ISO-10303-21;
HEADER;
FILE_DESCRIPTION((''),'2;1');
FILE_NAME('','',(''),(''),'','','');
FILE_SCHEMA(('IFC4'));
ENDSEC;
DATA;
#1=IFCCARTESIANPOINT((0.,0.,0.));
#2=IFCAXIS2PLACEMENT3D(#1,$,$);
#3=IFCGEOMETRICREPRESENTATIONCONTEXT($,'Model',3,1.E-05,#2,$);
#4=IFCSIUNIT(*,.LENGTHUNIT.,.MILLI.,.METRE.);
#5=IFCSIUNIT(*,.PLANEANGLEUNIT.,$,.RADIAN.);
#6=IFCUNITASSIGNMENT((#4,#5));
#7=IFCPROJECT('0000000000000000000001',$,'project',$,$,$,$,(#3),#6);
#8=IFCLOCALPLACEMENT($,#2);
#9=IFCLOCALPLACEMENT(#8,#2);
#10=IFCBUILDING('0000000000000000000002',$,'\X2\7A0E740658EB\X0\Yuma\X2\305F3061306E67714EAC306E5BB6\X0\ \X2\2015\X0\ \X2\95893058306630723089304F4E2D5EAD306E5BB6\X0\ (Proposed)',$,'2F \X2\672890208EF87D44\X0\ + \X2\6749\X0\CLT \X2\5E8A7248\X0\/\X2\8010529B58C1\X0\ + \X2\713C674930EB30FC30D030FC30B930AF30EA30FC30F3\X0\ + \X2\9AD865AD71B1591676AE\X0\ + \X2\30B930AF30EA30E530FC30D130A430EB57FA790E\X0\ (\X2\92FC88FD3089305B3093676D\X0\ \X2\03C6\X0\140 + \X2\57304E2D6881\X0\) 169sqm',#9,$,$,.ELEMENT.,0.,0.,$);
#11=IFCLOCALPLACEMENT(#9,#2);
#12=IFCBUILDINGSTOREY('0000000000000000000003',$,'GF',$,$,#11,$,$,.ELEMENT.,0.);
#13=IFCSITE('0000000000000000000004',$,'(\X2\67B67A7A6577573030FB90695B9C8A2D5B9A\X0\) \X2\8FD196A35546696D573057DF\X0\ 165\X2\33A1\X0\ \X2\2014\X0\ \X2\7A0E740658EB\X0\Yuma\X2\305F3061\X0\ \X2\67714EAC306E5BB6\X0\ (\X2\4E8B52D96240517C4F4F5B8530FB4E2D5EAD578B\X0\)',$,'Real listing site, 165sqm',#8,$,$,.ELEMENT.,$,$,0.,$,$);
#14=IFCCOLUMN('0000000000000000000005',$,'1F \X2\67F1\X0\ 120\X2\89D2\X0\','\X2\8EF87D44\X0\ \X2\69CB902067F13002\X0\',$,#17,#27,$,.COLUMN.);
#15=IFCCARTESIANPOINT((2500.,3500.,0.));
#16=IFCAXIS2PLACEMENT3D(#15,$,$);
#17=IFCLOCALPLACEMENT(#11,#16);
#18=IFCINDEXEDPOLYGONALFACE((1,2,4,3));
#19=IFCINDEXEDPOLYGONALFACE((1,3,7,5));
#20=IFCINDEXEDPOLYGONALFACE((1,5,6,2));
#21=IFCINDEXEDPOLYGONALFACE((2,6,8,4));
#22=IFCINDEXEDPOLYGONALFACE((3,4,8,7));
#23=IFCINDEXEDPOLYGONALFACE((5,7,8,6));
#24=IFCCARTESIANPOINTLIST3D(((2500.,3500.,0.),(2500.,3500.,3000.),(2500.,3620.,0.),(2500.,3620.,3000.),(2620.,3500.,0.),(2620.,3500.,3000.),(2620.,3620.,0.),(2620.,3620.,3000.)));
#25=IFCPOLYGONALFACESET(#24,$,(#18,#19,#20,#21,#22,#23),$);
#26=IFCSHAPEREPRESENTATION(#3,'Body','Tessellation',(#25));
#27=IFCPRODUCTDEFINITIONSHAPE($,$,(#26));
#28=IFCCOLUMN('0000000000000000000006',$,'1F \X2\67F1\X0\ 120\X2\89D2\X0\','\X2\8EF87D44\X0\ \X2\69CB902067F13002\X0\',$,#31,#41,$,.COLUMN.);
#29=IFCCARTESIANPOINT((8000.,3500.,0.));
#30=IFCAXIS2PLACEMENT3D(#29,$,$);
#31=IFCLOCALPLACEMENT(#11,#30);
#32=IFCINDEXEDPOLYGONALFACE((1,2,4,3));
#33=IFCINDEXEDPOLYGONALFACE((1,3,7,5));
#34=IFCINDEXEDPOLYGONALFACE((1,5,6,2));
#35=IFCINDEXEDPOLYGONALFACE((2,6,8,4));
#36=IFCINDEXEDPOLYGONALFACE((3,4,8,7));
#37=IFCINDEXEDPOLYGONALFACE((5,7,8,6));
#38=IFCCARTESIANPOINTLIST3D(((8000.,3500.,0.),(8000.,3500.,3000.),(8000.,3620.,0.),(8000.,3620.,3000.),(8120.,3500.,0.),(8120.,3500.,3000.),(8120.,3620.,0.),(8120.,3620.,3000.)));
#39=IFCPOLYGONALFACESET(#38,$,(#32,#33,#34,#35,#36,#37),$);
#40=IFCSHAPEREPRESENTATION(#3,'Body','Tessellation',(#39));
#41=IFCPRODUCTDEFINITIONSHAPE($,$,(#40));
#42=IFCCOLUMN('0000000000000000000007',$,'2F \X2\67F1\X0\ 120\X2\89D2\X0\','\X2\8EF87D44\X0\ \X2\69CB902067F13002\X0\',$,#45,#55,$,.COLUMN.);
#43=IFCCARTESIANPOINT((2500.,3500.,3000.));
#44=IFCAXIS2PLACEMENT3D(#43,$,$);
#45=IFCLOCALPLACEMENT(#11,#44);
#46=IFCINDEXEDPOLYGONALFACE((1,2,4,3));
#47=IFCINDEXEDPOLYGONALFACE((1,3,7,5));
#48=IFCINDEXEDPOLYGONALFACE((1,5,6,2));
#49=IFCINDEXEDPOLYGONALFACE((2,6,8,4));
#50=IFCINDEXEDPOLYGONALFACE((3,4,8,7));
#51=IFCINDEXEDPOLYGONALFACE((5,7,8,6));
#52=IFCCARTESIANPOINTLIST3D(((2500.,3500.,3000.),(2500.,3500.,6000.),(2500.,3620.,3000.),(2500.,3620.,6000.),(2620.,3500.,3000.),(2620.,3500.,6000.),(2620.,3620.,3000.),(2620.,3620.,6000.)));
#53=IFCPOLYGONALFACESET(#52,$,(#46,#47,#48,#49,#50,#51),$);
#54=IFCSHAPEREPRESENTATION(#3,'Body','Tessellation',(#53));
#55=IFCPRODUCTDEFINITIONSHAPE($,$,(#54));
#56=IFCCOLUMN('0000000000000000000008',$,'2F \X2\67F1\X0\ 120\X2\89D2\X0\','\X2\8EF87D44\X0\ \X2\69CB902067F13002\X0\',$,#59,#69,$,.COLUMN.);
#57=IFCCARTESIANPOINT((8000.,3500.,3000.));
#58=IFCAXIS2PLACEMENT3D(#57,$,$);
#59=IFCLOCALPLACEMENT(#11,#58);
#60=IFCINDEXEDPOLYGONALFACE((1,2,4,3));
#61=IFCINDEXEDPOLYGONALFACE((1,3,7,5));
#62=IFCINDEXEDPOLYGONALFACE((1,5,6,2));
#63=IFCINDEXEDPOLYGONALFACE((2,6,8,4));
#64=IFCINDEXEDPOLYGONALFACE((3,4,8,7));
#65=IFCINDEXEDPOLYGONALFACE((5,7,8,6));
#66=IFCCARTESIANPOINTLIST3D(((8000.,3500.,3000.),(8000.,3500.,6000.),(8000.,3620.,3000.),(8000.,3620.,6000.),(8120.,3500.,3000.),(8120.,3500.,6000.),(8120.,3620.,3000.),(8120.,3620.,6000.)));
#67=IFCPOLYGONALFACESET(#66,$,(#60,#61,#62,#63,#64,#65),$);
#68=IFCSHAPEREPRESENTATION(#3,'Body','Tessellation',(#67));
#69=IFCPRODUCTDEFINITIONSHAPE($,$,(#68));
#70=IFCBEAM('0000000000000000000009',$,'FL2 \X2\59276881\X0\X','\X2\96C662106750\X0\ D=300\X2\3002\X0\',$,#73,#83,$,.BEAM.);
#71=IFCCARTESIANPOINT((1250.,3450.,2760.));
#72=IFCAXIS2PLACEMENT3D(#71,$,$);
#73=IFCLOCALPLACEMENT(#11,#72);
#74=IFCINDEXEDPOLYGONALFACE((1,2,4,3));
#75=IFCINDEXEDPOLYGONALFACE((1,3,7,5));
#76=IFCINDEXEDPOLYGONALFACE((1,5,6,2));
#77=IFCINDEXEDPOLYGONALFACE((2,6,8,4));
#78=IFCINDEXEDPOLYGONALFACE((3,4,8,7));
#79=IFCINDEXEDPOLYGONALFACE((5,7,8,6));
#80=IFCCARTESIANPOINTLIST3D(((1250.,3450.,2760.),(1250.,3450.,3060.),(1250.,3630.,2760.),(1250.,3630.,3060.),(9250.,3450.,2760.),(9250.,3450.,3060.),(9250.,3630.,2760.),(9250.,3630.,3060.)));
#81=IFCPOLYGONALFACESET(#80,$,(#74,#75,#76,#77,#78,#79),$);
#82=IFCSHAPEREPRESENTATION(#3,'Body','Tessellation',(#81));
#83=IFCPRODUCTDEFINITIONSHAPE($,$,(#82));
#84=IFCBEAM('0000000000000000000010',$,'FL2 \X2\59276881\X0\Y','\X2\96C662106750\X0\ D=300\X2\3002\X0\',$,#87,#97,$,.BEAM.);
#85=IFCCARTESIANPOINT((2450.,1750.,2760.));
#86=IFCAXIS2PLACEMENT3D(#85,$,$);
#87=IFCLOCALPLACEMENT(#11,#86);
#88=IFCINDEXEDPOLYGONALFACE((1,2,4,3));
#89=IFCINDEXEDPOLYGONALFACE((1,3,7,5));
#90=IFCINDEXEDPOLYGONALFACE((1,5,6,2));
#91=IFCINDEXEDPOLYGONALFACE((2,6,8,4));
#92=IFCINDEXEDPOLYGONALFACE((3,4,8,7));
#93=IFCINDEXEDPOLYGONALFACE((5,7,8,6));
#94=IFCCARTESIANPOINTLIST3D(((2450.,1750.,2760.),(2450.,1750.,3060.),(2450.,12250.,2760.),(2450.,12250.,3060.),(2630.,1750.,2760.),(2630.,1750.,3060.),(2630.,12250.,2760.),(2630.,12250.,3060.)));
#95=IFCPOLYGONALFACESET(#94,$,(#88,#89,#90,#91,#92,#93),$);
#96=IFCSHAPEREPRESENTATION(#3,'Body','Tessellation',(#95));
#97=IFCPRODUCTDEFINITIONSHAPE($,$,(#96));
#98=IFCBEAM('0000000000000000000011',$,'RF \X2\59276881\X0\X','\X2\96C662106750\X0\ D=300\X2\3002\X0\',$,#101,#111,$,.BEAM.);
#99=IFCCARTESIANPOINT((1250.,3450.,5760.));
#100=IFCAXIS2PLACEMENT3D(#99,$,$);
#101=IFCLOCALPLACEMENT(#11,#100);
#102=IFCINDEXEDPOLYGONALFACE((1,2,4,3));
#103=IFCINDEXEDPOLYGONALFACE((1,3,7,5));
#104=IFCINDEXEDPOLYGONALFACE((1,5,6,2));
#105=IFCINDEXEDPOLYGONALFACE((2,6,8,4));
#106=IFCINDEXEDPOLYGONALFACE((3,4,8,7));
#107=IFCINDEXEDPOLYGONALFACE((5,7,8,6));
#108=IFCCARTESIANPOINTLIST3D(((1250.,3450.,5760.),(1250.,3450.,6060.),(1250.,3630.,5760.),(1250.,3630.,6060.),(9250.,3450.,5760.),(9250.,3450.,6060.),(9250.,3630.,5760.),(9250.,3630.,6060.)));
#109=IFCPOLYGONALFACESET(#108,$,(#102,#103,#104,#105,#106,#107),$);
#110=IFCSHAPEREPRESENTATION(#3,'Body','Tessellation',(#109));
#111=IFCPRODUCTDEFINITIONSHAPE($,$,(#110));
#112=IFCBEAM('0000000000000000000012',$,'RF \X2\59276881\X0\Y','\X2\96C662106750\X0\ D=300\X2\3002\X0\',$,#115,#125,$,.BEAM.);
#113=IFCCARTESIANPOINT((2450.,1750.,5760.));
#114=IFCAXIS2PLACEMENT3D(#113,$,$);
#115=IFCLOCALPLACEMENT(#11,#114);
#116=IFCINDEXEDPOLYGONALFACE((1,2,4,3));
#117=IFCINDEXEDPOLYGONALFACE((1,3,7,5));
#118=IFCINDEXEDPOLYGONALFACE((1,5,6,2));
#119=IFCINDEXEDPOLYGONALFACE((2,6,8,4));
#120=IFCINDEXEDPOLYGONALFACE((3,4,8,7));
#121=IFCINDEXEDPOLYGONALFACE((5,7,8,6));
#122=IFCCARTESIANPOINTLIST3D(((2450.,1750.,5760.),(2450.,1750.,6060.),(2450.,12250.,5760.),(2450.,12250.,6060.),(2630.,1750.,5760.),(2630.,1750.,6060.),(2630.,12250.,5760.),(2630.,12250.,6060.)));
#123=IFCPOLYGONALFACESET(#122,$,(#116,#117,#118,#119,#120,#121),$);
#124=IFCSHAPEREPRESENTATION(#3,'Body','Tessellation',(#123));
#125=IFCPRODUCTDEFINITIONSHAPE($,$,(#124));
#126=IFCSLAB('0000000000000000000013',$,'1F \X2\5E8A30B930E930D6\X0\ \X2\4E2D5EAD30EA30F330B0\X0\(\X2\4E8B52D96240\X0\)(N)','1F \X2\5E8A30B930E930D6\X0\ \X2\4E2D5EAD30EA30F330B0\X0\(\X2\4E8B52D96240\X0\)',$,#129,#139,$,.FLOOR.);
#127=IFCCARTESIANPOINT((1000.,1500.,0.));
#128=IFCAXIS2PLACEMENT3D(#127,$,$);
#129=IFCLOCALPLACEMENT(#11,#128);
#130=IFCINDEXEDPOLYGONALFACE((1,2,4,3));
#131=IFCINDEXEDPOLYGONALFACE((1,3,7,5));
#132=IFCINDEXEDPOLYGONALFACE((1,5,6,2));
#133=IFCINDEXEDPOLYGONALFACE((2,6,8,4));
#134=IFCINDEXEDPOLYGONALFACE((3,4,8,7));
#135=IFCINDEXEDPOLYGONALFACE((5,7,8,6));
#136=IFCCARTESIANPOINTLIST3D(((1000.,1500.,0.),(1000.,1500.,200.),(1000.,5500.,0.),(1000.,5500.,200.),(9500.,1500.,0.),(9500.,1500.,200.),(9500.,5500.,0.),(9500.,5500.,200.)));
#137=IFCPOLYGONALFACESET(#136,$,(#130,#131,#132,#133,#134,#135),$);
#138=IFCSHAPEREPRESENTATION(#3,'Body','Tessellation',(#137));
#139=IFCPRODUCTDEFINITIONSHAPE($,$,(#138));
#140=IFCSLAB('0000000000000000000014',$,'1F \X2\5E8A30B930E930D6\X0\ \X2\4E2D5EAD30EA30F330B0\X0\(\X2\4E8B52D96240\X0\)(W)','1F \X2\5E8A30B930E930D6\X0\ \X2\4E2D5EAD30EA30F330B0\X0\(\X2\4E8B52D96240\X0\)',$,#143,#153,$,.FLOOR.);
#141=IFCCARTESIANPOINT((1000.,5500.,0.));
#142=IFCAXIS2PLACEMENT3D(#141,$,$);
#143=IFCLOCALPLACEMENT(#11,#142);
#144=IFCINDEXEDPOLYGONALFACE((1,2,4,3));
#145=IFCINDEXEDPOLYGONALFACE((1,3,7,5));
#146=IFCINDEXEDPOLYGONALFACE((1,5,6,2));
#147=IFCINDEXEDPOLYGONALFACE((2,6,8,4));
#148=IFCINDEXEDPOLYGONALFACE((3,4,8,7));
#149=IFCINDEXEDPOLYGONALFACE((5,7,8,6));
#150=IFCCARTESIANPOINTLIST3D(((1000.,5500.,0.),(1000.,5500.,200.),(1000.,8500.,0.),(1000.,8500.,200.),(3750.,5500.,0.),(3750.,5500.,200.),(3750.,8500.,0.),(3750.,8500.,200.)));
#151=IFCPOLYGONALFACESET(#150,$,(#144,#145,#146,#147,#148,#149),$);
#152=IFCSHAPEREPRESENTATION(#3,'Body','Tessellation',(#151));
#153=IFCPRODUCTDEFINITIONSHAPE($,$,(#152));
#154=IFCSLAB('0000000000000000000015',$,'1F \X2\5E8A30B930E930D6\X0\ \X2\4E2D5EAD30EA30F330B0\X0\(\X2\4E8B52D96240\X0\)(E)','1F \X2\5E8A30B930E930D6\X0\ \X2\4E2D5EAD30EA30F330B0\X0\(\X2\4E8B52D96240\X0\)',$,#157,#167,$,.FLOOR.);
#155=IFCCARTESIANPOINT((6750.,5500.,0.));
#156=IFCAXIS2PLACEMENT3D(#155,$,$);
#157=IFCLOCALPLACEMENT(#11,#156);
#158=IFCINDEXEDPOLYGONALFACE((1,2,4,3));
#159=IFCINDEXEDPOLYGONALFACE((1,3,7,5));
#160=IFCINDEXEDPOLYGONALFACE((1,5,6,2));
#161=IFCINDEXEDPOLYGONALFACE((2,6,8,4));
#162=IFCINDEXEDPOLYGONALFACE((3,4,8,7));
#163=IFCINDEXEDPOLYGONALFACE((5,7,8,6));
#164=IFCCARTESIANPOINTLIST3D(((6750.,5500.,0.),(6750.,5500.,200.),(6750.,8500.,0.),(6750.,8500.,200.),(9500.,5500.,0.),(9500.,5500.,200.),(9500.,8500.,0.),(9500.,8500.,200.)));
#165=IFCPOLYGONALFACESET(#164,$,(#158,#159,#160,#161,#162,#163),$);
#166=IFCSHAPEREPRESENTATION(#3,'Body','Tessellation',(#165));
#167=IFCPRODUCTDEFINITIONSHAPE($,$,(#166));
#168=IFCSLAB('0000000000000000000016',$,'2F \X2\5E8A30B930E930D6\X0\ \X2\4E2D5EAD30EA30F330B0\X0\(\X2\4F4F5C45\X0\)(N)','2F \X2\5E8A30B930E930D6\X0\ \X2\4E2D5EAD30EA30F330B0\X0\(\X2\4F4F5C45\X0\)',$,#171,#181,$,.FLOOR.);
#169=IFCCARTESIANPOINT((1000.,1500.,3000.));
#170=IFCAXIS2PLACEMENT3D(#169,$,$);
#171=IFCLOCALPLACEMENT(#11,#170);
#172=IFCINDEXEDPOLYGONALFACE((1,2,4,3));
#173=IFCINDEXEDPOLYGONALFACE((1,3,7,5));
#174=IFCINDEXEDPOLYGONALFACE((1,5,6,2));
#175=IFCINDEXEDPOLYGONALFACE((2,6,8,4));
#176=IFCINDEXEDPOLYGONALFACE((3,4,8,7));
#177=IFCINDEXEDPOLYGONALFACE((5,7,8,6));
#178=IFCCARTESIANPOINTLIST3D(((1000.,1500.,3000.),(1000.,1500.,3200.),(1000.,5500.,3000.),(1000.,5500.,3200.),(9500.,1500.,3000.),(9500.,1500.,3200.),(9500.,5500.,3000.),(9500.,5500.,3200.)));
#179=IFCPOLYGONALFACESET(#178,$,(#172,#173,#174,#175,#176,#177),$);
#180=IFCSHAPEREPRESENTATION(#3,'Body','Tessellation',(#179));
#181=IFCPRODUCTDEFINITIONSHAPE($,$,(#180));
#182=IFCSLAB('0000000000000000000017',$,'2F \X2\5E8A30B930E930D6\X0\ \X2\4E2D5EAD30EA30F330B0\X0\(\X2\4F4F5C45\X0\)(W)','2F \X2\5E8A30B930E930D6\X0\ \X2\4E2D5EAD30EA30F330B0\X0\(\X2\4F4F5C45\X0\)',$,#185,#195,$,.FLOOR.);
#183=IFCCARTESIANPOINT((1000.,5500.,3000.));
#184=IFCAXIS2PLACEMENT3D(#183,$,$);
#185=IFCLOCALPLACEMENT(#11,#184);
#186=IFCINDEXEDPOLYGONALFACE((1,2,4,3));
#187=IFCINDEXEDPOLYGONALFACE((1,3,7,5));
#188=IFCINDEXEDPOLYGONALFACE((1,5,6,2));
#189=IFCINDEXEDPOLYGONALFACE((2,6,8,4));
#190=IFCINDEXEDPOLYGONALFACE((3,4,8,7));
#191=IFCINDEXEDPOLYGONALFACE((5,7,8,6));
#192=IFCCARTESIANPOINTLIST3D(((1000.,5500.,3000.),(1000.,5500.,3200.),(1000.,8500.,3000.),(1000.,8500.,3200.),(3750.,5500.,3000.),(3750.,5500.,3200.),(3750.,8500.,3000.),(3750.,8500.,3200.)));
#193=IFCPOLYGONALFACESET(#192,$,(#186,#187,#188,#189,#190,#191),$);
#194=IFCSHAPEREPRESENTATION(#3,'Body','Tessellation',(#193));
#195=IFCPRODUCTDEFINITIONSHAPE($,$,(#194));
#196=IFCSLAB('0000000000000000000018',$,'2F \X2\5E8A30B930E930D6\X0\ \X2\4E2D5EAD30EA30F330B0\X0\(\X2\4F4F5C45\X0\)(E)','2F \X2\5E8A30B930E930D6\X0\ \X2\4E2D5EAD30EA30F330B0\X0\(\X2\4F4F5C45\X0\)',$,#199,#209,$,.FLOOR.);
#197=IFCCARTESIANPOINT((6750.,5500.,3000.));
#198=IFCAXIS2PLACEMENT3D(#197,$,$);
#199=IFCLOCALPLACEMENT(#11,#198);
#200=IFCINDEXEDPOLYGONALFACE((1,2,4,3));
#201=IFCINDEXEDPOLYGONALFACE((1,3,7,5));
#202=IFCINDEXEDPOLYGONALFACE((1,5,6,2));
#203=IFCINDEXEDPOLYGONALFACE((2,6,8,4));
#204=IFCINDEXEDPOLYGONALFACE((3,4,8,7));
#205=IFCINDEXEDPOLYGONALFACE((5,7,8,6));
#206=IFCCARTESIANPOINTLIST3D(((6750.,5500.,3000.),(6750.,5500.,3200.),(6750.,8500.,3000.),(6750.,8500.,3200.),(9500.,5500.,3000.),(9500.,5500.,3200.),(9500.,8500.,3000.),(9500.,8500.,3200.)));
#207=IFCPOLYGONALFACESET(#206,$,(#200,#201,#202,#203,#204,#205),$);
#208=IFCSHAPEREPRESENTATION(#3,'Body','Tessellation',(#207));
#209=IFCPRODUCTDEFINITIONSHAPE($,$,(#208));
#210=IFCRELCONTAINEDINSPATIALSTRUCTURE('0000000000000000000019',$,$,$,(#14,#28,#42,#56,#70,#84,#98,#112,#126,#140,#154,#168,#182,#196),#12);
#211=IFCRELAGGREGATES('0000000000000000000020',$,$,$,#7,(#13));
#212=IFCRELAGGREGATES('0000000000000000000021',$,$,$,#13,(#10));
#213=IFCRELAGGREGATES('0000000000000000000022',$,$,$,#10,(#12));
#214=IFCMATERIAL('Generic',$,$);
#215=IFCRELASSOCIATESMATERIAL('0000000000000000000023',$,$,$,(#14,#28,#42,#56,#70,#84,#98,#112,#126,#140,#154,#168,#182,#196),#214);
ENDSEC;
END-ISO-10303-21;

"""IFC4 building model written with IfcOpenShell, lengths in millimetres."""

from ifc_helpers import new_model, si_unit, frame, frame_2d, origin, place, context, project, spatial, rectangle, extrude, material, element, save


model = new_model("IFC4")

# Units and contexts
model_context = context("Model", 3, precision=1e-05, world=origin())
ifc_project = project(units=[si_unit("LENGTHUNIT", "METRE", prefix="MILLI"), si_unit("PLANEANGLEUNIT", "RADIAN")], contexts=[model_context])

# Site, building, storey
site_placement = place(None, origin())
site = spatial("IfcSite", under=ifc_project, at=site_placement, Name="(架空敷地・適宜設定) 近隣商業地域 165㎡ — 税理士Yumaたち 東京の家 (事務所兼住宅・中庭型)", ObjectType="Real listing site, 165sqm", CompositionType="ELEMENT", RefElevation=0.0)
building_placement = place(site_placement, origin())
building = spatial("IfcBuilding", under=site, at=building_placement, Name="税理士Yumaたちの東京の家 ― 閉じてひらく中庭の家 (Proposed)", ObjectType="2F 木造軸組 + 杉CLT 床版/耐力壁 + 焼杉ルーバースクリーン + 高断熱外皮 + スクリューパイル基礎 (鋼製らせん杭 φ140 + 地中梁) 169sqm", CompositionType="ELEMENT", ElevationOfRefHeight=0.0, ElevationOfTerrain=0.0)
storey_placement = place(building_placement, origin())
storey = spatial("IfcBuildingStorey", under=building, at=storey_placement, Name="GF", CompositionType="ELEMENT", Elevation=0.0)

# Columns
ifc_material_1 = material(Name="Generic")
column_1_placement = place(storey_placement, frame((2500.0, 3500.0, 0.0)))
element("IfcColumn", 1, at=column_1_placement, inside=storey, material=ifc_material_1, Name="1F 柱 120角", Description="軸組 構造柱。", PredefinedType="COLUMN", context=model_context, shape_type="SweptSolid", body=[
    extrude(rectangle(XDim=120.0, YDim=120.0, at=frame_2d((60.0, 60.0))), frame((2500.0, 3500.0, 0.0)), (0.0, 0.0, 1.0), 3000.0),
])
column_2_placement = place(storey_placement, frame((8000.0, 3500.0, 0.0)))
element("IfcColumn", 2, at=column_2_placement, inside=storey, material=ifc_material_1, Name="1F 柱 120角", Description="軸組 構造柱。", PredefinedType="COLUMN", context=model_context, shape_type="SweptSolid", body=[
    extrude(rectangle(XDim=120.0, YDim=120.0, at=frame_2d((60.0, 60.0))), frame((8000.0, 3500.0, 0.0)), (0.0, 0.0, 1.0), 3000.0),
])
column_3_placement = place(storey_placement, frame((2500.0, 3500.0, 3000.0)))
element("IfcColumn", 3, at=column_3_placement, inside=storey, material=ifc_material_1, Name="2F 柱 120角", Description="軸組 構造柱。", PredefinedType="COLUMN", context=model_context, shape_type="SweptSolid", body=[
    extrude(rectangle(XDim=120.0, YDim=120.0, at=frame_2d((60.0, 60.0))), frame((2500.0, 3500.0, 3000.0)), (0.0, 0.0, 1.0), 3000.0),
])
column_4_placement = place(storey_placement, frame((8000.0, 3500.0, 3000.0)))
element("IfcColumn", 4, at=column_4_placement, inside=storey, material=ifc_material_1, Name="2F 柱 120角", Description="軸組 構造柱。", PredefinedType="COLUMN", context=model_context, shape_type="SweptSolid", body=[
    extrude(rectangle(XDim=120.0, YDim=120.0, at=frame_2d((60.0, 60.0))), frame((8000.0, 3500.0, 3000.0)), (0.0, 0.0, 1.0), 3000.0),
])

# Beams
beam_1_placement = place(storey_placement, frame((1250.0, 3450.0, 2760.0)))
element("IfcBeam", 5, at=beam_1_placement, inside=storey, material=ifc_material_1, Name="FL2 大梁X", Description="集成材 D=300。", PredefinedType="BEAM", context=model_context, shape_type="SweptSolid", body=[
    extrude(rectangle(XDim=8000.0, YDim=180.0, at=frame_2d((4000.0, 90.0))), frame((1250.0, 3450.0, 2760.0)), (0.0, 0.0, 1.0), 300.0),
])
beam_2_placement = place(storey_placement, frame((2450.0, 1750.0, 2760.0)))
element("IfcBeam", 6, at=beam_2_placement, inside=storey, material=ifc_material_1, Name="FL2 大梁Y", Description="集成材 D=300。", PredefinedType="BEAM", context=model_context, shape_type="SweptSolid", body=[
    extrude(rectangle(XDim=180.0, YDim=10500.0, at=frame_2d((90.0, 5250.0))), frame((2450.0, 1750.0, 2760.0)), (0.0, 0.0, 1.0), 300.0),
])
beam_3_placement = place(storey_placement, frame((1250.0, 3450.0, 5760.0)))
element("IfcBeam", 7, at=beam_3_placement, inside=storey, material=ifc_material_1, Name="RF 大梁X", Description="集成材 D=300。", PredefinedType="BEAM", context=model_context, shape_type="SweptSolid", body=[
    extrude(rectangle(XDim=8000.0, YDim=180.0, at=frame_2d((4000.0, 90.0))), frame((1250.0, 3450.0, 5760.0)), (0.0, 0.0, 1.0), 300.0),
])
beam_4_placement = place(storey_placement, frame((2450.0, 1750.0, 5760.0)))
element("IfcBeam", 8, at=beam_4_placement, inside=storey, material=ifc_material_1, Name="RF 大梁Y", Description="集成材 D=300。", PredefinedType="BEAM", context=model_context, shape_type="SweptSolid", body=[
    extrude(rectangle(XDim=180.0, YDim=10500.0, at=frame_2d((90.0, 5250.0))), frame((2450.0, 1750.0, 5760.0)), (0.0, 0.0, 1.0), 300.0),
])

# Slabs
slab_1_placement = place(storey_placement, frame((1000.0, 1500.0, 0.0)))
element("IfcSlab", 9, at=slab_1_placement, inside=storey, material=ifc_material_1, Name="1F 床スラブ 中庭リング(事務所)(N)", Description="1F 床スラブ 中庭リング(事務所)", PredefinedType="FLOOR", context=model_context, shape_type="SweptSolid", body=[
    extrude(rectangle(XDim=8500.0, YDim=4000.0, at=frame_2d((4250.0, 2000.0))), frame((1000.0, 1500.0, 0.0)), (0.0, 0.0, 1.0), 200.0),
])
slab_2_placement = place(storey_placement, frame((1000.0, 5500.0, 0.0)))
element("IfcSlab", 10, at=slab_2_placement, inside=storey, material=ifc_material_1, Name="1F 床スラブ 中庭リング(事務所)(W)", Description="1F 床スラブ 中庭リング(事務所)", PredefinedType="FLOOR", context=model_context, shape_type="SweptSolid", body=[
    extrude(rectangle(XDim=2750.0, YDim=3000.0, at=frame_2d((1375.0, 1500.0))), frame((1000.0, 5500.0, 0.0)), (0.0, 0.0, 1.0), 200.0),
])
slab_3_placement = place(storey_placement, frame((6750.0, 5500.0, 0.0)))
element("IfcSlab", 11, at=slab_3_placement, inside=storey, material=ifc_material_1, Name="1F 床スラブ 中庭リング(事務所)(E)", Description="1F 床スラブ 中庭リング(事務所)", PredefinedType="FLOOR", context=model_context, shape_type="SweptSolid", body=[
    extrude(rectangle(XDim=2750.0, YDim=3000.0, at=frame_2d((1375.0, 1500.0))), frame((6750.0, 5500.0, 0.0)), (0.0, 0.0, 1.0), 200.0),
])
slab_4_placement = place(storey_placement, frame((1000.0, 1500.0, 3000.0)))
element("IfcSlab", 12, at=slab_4_placement, inside=storey, material=ifc_material_1, Name="2F 床スラブ 中庭リング(住居)(N)", Description="2F 床スラブ 中庭リング(住居)", PredefinedType="FLOOR", context=model_context, shape_type="SweptSolid", body=[
    extrude(rectangle(XDim=8500.0, YDim=4000.0, at=frame_2d((4250.0, 2000.0))), frame((1000.0, 1500.0, 3000.0)), (0.0, 0.0, 1.0), 200.0),
])
slab_5_placement = place(storey_placement, frame((1000.0, 5500.0, 3000.0)))
element("IfcSlab", 13, at=slab_5_placement, inside=storey, material=ifc_material_1, Name="2F 床スラブ 中庭リング(住居)(W)", Description="2F 床スラブ 中庭リング(住居)", PredefinedType="FLOOR", context=model_context, shape_type="SweptSolid", body=[
    extrude(rectangle(XDim=2750.0, YDim=3000.0, at=frame_2d((1375.0, 1500.0))), frame((1000.0, 5500.0, 3000.0)), (0.0, 0.0, 1.0), 200.0),
])
slab_6_placement = place(storey_placement, frame((6750.0, 5500.0, 3000.0)))
element("IfcSlab", 14, at=slab_6_placement, inside=storey, material=ifc_material_1, Name="2F 床スラブ 中庭リング(住居)(E)", Description="2F 床スラブ 中庭リング(住居)", PredefinedType="FLOOR", context=model_context, shape_type="SweptSolid", body=[
    extrude(rectangle(XDim=2750.0, YDim=3000.0, at=frame_2d((1375.0, 1500.0))), frame((6750.0, 5500.0, 3000.0)), (0.0, 0.0, 1.0), 200.0),
])

save(model, "model.ifc")
